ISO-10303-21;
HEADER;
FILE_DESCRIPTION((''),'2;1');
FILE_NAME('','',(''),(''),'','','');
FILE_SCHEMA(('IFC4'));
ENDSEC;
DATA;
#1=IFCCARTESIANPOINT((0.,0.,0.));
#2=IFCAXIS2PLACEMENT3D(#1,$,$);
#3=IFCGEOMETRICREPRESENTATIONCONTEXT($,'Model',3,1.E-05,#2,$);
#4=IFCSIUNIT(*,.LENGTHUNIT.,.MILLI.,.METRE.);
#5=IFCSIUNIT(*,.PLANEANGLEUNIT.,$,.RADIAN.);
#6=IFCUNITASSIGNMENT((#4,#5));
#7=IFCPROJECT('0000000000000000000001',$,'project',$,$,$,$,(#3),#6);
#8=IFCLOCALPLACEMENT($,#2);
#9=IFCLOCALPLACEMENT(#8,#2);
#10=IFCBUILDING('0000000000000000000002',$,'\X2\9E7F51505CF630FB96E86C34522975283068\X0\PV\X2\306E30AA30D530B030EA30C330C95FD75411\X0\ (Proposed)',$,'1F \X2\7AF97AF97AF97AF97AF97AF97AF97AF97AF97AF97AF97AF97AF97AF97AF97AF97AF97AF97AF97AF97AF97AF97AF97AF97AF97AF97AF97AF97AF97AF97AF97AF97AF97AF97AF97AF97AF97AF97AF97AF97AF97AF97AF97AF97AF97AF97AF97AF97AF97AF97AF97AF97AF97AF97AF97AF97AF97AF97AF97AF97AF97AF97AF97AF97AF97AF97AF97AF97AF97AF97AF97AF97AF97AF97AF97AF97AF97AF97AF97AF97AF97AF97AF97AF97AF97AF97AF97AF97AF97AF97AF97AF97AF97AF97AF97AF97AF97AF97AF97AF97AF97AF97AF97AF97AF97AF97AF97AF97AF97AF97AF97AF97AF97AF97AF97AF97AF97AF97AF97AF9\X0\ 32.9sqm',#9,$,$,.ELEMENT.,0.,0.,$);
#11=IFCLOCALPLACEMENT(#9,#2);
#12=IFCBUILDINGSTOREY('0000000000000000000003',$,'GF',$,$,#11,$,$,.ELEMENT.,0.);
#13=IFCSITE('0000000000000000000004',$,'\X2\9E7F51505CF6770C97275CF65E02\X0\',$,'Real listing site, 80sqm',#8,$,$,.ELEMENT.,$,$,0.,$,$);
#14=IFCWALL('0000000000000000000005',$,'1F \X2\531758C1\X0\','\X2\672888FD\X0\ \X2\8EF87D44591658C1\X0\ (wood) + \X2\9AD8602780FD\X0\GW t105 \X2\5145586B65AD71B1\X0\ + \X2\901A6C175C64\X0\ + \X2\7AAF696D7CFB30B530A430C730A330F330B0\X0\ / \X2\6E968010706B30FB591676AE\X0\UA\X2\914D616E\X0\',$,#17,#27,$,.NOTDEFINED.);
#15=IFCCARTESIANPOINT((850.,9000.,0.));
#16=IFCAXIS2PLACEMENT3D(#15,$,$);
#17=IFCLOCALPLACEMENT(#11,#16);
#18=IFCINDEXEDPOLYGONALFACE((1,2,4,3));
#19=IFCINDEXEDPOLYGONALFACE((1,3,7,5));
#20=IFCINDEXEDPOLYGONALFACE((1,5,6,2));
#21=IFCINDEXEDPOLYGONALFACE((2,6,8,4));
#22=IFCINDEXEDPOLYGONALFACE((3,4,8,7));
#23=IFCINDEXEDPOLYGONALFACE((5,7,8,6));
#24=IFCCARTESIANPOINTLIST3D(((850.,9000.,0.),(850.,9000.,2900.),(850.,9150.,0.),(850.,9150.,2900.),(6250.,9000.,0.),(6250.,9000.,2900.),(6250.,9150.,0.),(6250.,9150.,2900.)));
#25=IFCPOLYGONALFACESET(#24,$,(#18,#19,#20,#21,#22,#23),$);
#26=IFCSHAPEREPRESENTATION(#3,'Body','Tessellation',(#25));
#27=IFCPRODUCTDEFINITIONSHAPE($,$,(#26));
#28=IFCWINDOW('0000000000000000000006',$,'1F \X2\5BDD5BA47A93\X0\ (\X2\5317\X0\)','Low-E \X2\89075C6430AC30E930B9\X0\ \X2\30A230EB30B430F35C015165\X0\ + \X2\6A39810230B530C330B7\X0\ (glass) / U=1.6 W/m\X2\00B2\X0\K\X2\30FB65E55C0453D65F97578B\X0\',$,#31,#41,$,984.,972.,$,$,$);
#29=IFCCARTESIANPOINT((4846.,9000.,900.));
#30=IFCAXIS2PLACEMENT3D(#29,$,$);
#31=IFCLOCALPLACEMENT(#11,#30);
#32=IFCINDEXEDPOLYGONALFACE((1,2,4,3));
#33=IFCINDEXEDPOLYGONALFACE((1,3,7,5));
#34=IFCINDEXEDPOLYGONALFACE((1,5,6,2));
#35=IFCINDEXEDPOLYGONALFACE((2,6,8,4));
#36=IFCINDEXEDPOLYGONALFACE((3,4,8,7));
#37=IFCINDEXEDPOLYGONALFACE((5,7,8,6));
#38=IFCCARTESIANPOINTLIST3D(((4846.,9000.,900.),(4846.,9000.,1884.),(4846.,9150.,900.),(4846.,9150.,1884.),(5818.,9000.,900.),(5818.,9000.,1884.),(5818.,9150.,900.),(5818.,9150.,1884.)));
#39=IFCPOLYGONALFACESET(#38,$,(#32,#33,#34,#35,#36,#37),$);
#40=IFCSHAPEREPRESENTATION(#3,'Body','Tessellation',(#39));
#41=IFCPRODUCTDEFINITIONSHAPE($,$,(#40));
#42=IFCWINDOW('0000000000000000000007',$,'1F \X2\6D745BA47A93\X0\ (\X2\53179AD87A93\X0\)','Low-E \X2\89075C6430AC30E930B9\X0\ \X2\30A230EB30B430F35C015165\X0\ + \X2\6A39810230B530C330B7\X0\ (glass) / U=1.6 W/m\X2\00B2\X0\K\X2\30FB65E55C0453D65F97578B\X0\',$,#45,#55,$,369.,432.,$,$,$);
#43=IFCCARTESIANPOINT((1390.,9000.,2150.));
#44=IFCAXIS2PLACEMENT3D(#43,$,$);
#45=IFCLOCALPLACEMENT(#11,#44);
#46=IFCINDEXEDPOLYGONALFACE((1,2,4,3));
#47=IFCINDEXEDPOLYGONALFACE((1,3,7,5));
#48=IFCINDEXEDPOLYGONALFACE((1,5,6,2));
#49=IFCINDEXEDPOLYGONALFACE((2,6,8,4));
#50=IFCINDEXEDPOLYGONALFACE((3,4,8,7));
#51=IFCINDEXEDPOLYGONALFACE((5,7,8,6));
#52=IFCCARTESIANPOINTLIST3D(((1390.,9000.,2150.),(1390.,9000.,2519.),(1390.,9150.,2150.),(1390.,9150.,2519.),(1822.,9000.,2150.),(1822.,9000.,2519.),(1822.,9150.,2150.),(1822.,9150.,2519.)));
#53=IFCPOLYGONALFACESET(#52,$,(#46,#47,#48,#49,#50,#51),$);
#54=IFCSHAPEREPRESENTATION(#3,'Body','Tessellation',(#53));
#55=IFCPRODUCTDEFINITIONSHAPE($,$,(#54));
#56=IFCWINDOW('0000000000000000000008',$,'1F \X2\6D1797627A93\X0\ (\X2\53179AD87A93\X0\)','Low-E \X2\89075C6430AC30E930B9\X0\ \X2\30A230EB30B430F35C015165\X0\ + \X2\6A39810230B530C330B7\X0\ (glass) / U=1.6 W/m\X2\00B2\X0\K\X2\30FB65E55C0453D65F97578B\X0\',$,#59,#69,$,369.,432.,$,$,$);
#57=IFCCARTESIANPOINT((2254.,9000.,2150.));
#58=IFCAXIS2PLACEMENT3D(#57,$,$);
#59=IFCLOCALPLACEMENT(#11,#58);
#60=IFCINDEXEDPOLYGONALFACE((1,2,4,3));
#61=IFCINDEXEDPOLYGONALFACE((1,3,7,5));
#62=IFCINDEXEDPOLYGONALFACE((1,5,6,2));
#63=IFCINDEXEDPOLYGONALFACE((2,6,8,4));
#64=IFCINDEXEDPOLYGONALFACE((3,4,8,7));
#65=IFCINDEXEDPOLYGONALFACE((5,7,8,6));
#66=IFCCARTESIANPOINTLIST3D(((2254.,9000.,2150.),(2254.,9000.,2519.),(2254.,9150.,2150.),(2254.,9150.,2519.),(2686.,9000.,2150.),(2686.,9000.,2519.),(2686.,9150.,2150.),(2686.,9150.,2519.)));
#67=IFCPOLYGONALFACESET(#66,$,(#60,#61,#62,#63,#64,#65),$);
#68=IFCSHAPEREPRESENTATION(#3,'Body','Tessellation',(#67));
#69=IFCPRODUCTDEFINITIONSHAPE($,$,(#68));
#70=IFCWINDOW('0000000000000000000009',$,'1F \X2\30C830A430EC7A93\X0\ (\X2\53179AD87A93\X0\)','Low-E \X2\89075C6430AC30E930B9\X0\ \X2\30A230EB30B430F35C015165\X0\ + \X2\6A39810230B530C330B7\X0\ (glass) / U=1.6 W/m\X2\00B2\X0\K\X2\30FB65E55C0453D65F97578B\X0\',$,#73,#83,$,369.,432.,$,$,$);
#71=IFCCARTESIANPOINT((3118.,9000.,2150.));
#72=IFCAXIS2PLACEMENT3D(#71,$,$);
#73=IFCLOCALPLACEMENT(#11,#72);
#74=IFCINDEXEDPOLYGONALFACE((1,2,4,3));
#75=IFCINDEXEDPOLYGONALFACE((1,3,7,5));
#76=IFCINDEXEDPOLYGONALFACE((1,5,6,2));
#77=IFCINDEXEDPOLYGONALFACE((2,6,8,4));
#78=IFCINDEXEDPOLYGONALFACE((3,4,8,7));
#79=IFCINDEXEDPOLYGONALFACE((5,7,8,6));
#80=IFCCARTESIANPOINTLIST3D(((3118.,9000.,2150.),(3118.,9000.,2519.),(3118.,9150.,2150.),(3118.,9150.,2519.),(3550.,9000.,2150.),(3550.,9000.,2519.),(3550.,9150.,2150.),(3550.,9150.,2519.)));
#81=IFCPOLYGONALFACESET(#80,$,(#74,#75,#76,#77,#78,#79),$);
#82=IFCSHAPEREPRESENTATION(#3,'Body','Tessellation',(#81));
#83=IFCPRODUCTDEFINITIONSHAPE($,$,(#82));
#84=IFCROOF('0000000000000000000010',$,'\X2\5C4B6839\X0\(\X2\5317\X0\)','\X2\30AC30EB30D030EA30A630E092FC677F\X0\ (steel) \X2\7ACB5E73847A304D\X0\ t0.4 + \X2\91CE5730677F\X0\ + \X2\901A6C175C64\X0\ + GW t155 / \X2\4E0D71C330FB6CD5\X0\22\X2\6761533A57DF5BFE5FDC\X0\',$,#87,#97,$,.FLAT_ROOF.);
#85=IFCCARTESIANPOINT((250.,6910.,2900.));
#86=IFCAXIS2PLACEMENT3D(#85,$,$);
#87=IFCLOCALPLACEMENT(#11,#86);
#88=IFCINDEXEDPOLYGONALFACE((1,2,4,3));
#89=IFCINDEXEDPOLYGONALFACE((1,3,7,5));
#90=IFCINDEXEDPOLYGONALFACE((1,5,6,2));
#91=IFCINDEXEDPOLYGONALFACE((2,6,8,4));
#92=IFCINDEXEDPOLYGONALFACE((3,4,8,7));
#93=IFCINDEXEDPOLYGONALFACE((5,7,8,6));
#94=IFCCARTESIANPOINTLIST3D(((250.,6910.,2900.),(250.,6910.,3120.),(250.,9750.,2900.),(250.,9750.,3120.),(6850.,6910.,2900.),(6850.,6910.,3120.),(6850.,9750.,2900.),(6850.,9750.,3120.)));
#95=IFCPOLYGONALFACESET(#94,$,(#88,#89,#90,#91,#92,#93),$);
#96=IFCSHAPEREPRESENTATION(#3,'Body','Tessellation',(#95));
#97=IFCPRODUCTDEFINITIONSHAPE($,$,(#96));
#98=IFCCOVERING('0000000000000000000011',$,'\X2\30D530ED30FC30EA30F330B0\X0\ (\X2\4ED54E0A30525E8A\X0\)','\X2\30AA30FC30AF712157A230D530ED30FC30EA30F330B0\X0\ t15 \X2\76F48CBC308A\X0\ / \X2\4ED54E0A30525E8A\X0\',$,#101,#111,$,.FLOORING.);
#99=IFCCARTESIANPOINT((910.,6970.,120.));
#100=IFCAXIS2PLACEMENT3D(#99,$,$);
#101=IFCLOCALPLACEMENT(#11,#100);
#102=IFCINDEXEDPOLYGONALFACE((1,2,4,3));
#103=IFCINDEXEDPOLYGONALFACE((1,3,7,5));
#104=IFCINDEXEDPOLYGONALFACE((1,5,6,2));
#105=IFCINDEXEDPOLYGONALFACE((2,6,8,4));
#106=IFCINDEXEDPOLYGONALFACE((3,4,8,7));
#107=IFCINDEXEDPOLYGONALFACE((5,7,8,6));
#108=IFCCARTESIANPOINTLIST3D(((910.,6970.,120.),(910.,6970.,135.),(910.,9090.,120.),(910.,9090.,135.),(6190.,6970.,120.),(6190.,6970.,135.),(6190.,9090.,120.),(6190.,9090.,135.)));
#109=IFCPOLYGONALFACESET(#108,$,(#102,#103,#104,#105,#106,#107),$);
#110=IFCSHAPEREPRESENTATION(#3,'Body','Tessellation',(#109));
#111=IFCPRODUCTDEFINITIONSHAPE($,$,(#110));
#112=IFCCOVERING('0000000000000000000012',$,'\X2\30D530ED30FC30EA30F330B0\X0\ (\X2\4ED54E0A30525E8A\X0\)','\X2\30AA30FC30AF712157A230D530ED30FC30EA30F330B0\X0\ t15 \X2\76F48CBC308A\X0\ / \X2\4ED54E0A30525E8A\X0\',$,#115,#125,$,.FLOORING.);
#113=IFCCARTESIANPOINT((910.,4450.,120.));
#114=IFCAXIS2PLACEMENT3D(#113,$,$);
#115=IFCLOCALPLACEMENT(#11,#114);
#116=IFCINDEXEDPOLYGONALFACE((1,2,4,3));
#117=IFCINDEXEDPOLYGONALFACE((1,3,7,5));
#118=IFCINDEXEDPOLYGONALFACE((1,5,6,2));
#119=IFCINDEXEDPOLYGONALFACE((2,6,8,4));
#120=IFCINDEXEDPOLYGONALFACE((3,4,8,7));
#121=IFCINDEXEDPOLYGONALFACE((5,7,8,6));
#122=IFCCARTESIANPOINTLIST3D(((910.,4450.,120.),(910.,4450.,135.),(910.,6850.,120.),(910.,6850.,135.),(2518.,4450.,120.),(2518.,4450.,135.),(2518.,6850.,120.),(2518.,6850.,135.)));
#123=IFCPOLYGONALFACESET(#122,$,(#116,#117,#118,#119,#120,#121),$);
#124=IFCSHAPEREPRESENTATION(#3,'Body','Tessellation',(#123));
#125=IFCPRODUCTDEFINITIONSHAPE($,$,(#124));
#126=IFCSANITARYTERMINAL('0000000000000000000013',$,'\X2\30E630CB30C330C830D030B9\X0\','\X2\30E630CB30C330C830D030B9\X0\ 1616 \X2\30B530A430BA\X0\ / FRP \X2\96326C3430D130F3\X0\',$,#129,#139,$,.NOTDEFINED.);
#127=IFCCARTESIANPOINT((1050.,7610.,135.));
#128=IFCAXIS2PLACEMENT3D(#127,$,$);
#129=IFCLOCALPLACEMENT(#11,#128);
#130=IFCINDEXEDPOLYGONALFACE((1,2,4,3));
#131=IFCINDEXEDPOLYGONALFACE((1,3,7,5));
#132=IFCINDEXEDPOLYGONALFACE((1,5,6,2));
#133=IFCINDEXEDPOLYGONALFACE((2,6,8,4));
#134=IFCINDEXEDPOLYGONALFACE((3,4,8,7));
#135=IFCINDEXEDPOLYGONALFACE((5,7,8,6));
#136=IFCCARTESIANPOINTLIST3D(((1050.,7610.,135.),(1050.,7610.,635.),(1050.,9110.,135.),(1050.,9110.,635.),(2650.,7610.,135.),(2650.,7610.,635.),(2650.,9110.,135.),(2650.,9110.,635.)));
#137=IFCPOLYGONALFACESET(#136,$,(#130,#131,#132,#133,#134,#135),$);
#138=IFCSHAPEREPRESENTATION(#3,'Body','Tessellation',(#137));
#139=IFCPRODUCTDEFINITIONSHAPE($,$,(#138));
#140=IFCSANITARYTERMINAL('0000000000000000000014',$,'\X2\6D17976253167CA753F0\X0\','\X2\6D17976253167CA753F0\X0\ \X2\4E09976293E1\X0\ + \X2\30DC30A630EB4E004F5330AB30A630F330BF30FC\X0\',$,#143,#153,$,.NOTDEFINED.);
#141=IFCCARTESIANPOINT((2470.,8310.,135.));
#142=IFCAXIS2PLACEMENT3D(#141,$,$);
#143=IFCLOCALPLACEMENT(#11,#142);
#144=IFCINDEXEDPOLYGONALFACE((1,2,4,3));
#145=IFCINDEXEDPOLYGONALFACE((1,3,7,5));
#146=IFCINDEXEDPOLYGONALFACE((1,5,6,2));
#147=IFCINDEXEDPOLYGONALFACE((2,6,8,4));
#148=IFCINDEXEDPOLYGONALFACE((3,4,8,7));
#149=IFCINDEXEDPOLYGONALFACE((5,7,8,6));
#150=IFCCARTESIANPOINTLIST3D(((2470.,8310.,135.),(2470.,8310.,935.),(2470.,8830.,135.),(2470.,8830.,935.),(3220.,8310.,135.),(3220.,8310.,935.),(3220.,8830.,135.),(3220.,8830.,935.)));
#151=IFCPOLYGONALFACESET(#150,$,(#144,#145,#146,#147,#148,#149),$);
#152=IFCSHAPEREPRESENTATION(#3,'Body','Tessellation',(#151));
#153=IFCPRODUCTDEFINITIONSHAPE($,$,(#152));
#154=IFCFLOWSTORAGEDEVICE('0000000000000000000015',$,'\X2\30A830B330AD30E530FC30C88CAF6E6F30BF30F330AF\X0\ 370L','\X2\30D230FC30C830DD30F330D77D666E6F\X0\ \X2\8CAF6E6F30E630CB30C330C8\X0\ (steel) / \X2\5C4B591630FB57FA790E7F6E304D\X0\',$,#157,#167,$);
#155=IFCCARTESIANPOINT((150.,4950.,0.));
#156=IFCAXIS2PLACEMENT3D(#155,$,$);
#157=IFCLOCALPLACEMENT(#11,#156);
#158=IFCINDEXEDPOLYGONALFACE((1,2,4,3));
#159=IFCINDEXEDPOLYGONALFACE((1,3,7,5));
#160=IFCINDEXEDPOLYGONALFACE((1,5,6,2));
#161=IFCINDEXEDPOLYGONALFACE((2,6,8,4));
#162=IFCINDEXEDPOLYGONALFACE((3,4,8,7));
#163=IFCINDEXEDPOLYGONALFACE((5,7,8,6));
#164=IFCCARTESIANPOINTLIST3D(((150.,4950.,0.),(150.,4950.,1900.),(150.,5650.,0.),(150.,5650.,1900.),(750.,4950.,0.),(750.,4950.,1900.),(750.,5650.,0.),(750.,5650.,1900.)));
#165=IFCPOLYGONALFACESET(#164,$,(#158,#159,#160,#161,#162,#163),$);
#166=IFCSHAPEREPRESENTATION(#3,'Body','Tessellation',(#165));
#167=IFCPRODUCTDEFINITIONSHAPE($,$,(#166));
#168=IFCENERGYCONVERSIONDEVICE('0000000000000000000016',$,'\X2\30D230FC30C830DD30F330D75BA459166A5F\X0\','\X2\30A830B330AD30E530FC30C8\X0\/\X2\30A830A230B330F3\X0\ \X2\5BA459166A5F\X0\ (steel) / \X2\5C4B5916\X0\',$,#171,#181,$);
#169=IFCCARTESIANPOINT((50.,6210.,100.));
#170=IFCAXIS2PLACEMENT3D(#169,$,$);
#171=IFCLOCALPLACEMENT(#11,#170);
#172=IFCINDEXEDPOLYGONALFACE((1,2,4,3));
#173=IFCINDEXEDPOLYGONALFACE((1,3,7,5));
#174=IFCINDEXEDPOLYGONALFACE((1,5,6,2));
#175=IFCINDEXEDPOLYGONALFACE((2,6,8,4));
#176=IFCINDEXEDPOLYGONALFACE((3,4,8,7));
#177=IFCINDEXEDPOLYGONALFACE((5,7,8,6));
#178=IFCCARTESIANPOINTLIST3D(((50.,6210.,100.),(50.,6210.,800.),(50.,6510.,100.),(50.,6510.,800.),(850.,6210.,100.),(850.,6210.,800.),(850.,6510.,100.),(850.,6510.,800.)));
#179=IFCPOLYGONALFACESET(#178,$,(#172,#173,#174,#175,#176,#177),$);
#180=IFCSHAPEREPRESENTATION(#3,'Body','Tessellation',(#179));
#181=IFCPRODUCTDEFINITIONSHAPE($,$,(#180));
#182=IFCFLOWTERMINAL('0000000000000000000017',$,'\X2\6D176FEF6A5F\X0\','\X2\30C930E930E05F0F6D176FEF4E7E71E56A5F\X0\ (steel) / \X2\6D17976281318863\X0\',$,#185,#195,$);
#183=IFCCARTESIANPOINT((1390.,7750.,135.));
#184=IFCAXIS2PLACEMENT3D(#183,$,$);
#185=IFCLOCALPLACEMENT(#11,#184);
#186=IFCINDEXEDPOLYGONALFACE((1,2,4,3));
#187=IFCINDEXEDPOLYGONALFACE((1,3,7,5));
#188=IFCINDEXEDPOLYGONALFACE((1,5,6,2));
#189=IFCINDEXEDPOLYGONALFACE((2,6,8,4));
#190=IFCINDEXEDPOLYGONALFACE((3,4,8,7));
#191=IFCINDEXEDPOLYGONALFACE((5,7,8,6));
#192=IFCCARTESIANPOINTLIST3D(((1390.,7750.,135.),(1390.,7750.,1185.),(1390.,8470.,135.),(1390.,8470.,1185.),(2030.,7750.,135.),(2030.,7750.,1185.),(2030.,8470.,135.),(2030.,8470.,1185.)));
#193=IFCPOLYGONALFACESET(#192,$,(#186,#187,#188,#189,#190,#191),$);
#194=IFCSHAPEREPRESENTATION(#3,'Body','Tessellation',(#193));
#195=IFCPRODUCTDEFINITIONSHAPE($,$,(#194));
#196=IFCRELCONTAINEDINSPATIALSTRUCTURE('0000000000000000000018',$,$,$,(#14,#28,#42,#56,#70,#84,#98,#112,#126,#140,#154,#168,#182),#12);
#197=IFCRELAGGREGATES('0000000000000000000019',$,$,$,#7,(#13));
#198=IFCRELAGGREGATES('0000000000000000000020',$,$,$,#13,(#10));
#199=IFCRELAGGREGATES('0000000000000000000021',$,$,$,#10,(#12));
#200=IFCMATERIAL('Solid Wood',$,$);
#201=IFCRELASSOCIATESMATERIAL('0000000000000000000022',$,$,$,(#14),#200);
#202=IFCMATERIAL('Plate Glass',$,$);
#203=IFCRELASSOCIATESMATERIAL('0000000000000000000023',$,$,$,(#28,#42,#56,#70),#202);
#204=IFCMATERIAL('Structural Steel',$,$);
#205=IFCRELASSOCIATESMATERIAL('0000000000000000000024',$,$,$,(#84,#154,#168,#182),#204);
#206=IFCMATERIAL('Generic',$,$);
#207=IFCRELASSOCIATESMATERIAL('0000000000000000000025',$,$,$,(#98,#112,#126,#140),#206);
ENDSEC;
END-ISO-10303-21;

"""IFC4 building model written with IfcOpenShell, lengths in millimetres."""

from ifc_helpers import new_model, si_unit, frame, frame_2d, origin, place, context, project, spatial, rectangle, extrude, material, element, fill, save


model = new_model("IFC4")

# Units and contexts
model_context = context("Model", 3, precision=1e-05, world=origin())
ifc_project = project(units=[si_unit("LENGTHUNIT", "METRE", prefix="MILLI"), si_unit("PLANEANGLEUNIT", "RADIAN")], contexts=[model_context])

# Site, building, storey
site_placement = place(None, origin())
site = spatial("IfcSite", under=ifc_project, at=site_placement, Name="鹿児島県霧島市", ObjectType="Real listing site, 80sqm", CompositionType="ELEMENT", RefElevation=0.0)
building_placement = place(site_placement, origin())
building = spatial("IfcBuilding", under=site, at=building_placement, Name="鹿児島・雨水利用とPVのオフグリッド志向 (Proposed)", ObjectType="1F 竹竹竹竹竹竹竹竹竹竹竹竹竹竹竹竹竹竹竹竹竹竹竹竹竹竹竹竹竹竹竹竹竹竹竹竹竹竹竹竹竹竹竹竹竹竹竹竹竹竹竹竹竹竹竹竹竹竹竹竹竹竹竹竹竹竹竹竹竹竹竹竹竹竹竹竹竹竹竹竹竹竹竹竹竹竹竹竹竹竹竹竹竹竹竹竹竹竹竹竹竹竹竹竹竹竹竹竹竹竹竹竹竹竹竹竹竹竹竹竹 32.9sqm", CompositionType="ELEMENT", ElevationOfRefHeight=0.0, ElevationOfTerrain=0.0)
storey_placement = place(building_placement, origin())
storey = spatial("IfcBuildingStorey", under=building, at=storey_placement, Name="GF", CompositionType="ELEMENT", Elevation=0.0)

# Shared definitions
ifc_material_1 = material(Name="Solid Wood")

# Wall, openings, windows
wall_1_placement = place(storey_placement, frame((850.0, 9000.0, 0.0)))
wall_1 = element("IfcWall", 1, at=wall_1_placement, inside=storey, material=ifc_material_1, Name="1F 北壁", Description="木製 軸組外壁 (wood) + 高性能GW t105 充填断熱 + 通気層 + 窯業系サイディング / 準耐火・外皮UA配慮", PredefinedType="NOTDEFINED", context=model_context, shape_type="SweptSolid", body=[
    extrude(rectangle(XDim=5400.0, YDim=150.0, at=frame_2d((2700.0, 75.0))), frame((850.0, 9000.0, 0.0)), (0.0, 0.0, 1.0), 2900.0),
])
opening_1_placement = place(storey_placement, frame((4846.0, 9000.0, 900.0)))
opening_1 = element("IfcOpeningElement", 2, at=opening_1_placement, cuts=wall_1, PredefinedType="NOTDEFINED", context=model_context, shape_type="SweptSolid", body=[
    extrude(rectangle(XDim=972.0, YDim=150.0, at=frame_2d((486.0, 75.0))), frame((4846.0, 9000.0, 900.0)), (0.0, 0.0, 1.0), 984.0),
])
opening_2_placement = place(storey_placement, frame((1390.0, 9000.0, 2150.0)))
opening_2 = element("IfcOpeningElement", 3, at=opening_2_placement, cuts=wall_1, PredefinedType="NOTDEFINED", context=model_context, shape_type="SweptSolid", body=[
    extrude(rectangle(XDim=432.0, YDim=150.0, at=frame_2d((216.0, 75.0))), frame((1390.0, 9000.0, 2150.0)), (0.0, 0.0, 1.0), 369.0),
])
opening_3_placement = place(storey_placement, frame((2254.0, 9000.0, 2150.0)))
opening_3 = element("IfcOpeningElement", 4, at=opening_3_placement, cuts=wall_1, PredefinedType="NOTDEFINED", context=model_context, shape_type="SweptSolid", body=[
    extrude(rectangle(XDim=432.0, YDim=150.0, at=frame_2d((216.0, 75.0))), frame((2254.0, 9000.0, 2150.0)), (0.0, 0.0, 1.0), 369.0),
])
opening_4_placement = place(storey_placement, frame((3118.0, 9000.0, 2150.0)))
opening_4 = element("IfcOpeningElement", 5, at=opening_4_placement, cuts=wall_1, PredefinedType="NOTDEFINED", context=model_context, shape_type="SweptSolid", body=[
    extrude(rectangle(XDim=432.0, YDim=150.0, at=frame_2d((216.0, 75.0))), frame((3118.0, 9000.0, 2150.0)), (0.0, 0.0, 1.0), 369.0),
])
ifc_material_2 = material(Name="Plate Glass")
window_1_placement = place(storey_placement, frame((4846.0, 9000.0, 900.0)))
window_1 = element("IfcWindow", 6, at=window_1_placement, inside=storey, material=ifc_material_2, Name="1F 寝室窓 (北)", Description="Low-E 複層ガラス アルゴン封入 + 樹脂サッシ (glass) / U=1.6 W/m²K・日射取得型", OverallHeight=984.0, OverallWidth=972.0, context=model_context, shape_type="SweptSolid", body=[
    extrude(rectangle(XDim=972.0, YDim=150.0, at=frame_2d((486.0, 75.0))), frame((4846.0, 9000.0, 900.0)), (0.0, 0.0, 1.0), 984.0),
])
fill(opening_1, window_1)
window_2_placement = place(storey_placement, frame((1390.0, 9000.0, 2150.0)))
window_2 = element("IfcWindow", 7, at=window_2_placement, inside=storey, material=ifc_material_2, Name="1F 浴室窓 (北高窓)", Description="Low-E 複層ガラス アルゴン封入 + 樹脂サッシ (glass) / U=1.6 W/m²K・日射取得型", OverallHeight=369.0, OverallWidth=432.0, context=model_context, shape_type="SweptSolid", body=[
    extrude(rectangle(XDim=432.0, YDim=150.0, at=frame_2d((216.0, 75.0))), frame((1390.0, 9000.0, 2150.0)), (0.0, 0.0, 1.0), 369.0),
])
fill(opening_2, window_2)
window_3_placement = place(storey_placement, frame((2254.0, 9000.0, 2150.0)))
window_3 = element("IfcWindow", 8, at=window_3_placement, inside=storey, material=ifc_material_2, Name="1F 洗面窓 (北高窓)", Description="Low-E 複層ガラス アルゴン封入 + 樹脂サッシ (glass) / U=1.6 W/m²K・日射取得型", OverallHeight=369.0, OverallWidth=432.0, context=model_context, shape_type="SweptSolid", body=[
    extrude(rectangle(XDim=432.0, YDim=150.0, at=frame_2d((216.0, 75.0))), frame((2254.0, 9000.0, 2150.0)), (0.0, 0.0, 1.0), 369.0),
])
fill(opening_3, window_3)
window_4_placement = place(storey_placement, frame((3118.0, 9000.0, 2150.0)))
window_4 = element("IfcWindow", 9, at=window_4_placement, inside=storey, material=ifc_material_2, Name="1F トイレ窓 (北高窓)", Description="Low-E 複層ガラス アルゴン封入 + 樹脂サッシ (glass) / U=1.6 W/m²K・日射取得型", OverallHeight=369.0, OverallWidth=432.0, context=model_context, shape_type="SweptSolid", body=[
    extrude(rectangle(XDim=432.0, YDim=150.0, at=frame_2d((216.0, 75.0))), frame((3118.0, 9000.0, 2150.0)), (0.0, 0.0, 1.0), 369.0),
])
fill(opening_4, window_4)

# Roof
ifc_material_3 = material(Name="Structural Steel")
roof_placement = place(storey_placement, frame((250.0, 6910.0, 2900.0)))
element("IfcRoof", 10, at=roof_placement, inside=storey, material=ifc_material_3, Name="屋根(北)", Description="ガルバリウム鋼板 (steel) 立平葺き t0.4 + 野地板 + 通気層 + GW t155 / 不燃・法22条区域対応", PredefinedType="FLAT_ROOF", context=model_context, shape_type="SweptSolid", body=[
    extrude(rectangle(XDim=6600.0, YDim=2840.0, at=frame_2d((3300.0, 1420.0))), frame((250.0, 6910.0, 2900.0)), (0.0, 0.0, 1.0), 220.0),
])

# Coverings
ifc_material_4 = material(Name="Generic")
covering_1_placement = place(storey_placement, frame((910.0, 6970.0, 120.0)))
element("IfcCovering", 11, at=covering_1_placement, inside=storey, material=ifc_material_4, Name="フローリング (仕上げ床)", Description="オーク無垢フローリング t15 直貼り / 仕上げ床", PredefinedType="FLOORING", context=model_context, shape_type="SweptSolid", body=[
    extrude(rectangle(XDim=5280.0, YDim=2120.0, at=frame_2d((2640.0, 1060.0))), frame((910.0, 6970.0, 120.0)), (0.0, 0.0, 1.0), 15.0),
])
covering_2_placement = place(storey_placement, frame((910.0, 4450.0, 120.0)))
element("IfcCovering", 12, at=covering_2_placement, inside=storey, material=ifc_material_4, Name="フローリング (仕上げ床)", Description="オーク無垢フローリング t15 直貼り / 仕上げ床", PredefinedType="FLOORING", context=model_context, shape_type="SweptSolid", body=[
    extrude(rectangle(XDim=1608.0, YDim=2400.0, at=frame_2d((804.0, 1200.0))), frame((910.0, 4450.0, 120.0)), (0.0, 0.0, 1.0), 15.0),
])

# Sanitary terminals
sanitary_terminal_1_placement = place(storey_placement, frame((1050.0, 7610.0, 135.0)))
element("IfcSanitaryTerminal", 13, at=sanitary_terminal_1_placement, inside=storey, material=ifc_material_4, Name="ユニットバス", Description="ユニットバス 1616 サイズ / FRP 防水パン", PredefinedType="NOTDEFINED", context=model_context, shape_type="SweptSolid", body=[
    extrude(rectangle(XDim=1600.0, YDim=1500.0, at=frame_2d((800.0, 750.0))), frame((1050.0, 7610.0, 135.0)), (0.0, 0.0, 1.0), 500.0),
])
sanitary_terminal_2_placement = place(storey_placement, frame((2470.0, 8310.0, 135.0)))
element("IfcSanitaryTerminal", 14, at=sanitary_terminal_2_placement, inside=storey, material=ifc_material_4, Name="洗面化粧台", Description="洗面化粧台 三面鏡 + ボウル一体カウンター", PredefinedType="NOTDEFINED", context=model_context, shape_type="SweptSolid", body=[
    extrude(rectangle(XDim=750.0, YDim=520.0, at=frame_2d((375.0, 260.0))), frame((2470.0, 8310.0, 135.0)), (0.0, 0.0, 1.0), 800.0),
])

# Flow storage device
flow_storage_device_placement = place(storey_placement, frame((150.0, 4950.0, 0.0)))
element("IfcFlowStorageDevice", 15, at=flow_storage_device_placement, inside=storey, material=ifc_material_3, Name="エコキュート貯湯タンク 370L", Description="ヒートポンプ給湯 貯湯ユニット (steel) / 屋外・基礎置き", context=model_context, shape_type="SweptSolid", body=[
    extrude(rectangle(XDim=600.0, YDim=700.0, at=frame_2d((300.0, 350.0))), frame((150.0, 4950.0, 0.0)), (0.0, 0.0, 1.0), 1900.0),
])

# Energy conversion device
energy_conversion_device_placement = place(storey_placement, frame((50.0, 6210.0, 100.0)))
element("IfcEnergyConversionDevice", 16, at=energy_conversion_device_placement, inside=storey, material=ifc_material_3, Name="ヒートポンプ室外機", Description="エコキュート/エアコン 室外機 (steel) / 屋外", context=model_context, shape_type="SweptSolid", body=[
    extrude(rectangle(XDim=800.0, YDim=300.0, at=frame_2d((400.0, 150.0))), frame((50.0, 6210.0, 100.0)), (0.0, 0.0, 1.0), 700.0),
])

# Flow terminal
flow_terminal_placement = place(storey_placement, frame((1390.0, 7750.0, 135.0)))
element("IfcFlowTerminal", 17, at=flow_terminal_placement, inside=storey, material=ifc_material_3, Name="洗濯機", Description="ドラム式洗濯乾燥機 (steel) / 洗面脱衣", context=model_context, shape_type="SweptSolid", body=[
    extrude(rectangle(XDim=640.0, YDim=720.0, at=frame_2d((320.0, 360.0))), frame((1390.0, 7750.0, 135.0)), (0.0, 0.0, 1.0), 1050.0),
])

save(model, "model.ifc")
